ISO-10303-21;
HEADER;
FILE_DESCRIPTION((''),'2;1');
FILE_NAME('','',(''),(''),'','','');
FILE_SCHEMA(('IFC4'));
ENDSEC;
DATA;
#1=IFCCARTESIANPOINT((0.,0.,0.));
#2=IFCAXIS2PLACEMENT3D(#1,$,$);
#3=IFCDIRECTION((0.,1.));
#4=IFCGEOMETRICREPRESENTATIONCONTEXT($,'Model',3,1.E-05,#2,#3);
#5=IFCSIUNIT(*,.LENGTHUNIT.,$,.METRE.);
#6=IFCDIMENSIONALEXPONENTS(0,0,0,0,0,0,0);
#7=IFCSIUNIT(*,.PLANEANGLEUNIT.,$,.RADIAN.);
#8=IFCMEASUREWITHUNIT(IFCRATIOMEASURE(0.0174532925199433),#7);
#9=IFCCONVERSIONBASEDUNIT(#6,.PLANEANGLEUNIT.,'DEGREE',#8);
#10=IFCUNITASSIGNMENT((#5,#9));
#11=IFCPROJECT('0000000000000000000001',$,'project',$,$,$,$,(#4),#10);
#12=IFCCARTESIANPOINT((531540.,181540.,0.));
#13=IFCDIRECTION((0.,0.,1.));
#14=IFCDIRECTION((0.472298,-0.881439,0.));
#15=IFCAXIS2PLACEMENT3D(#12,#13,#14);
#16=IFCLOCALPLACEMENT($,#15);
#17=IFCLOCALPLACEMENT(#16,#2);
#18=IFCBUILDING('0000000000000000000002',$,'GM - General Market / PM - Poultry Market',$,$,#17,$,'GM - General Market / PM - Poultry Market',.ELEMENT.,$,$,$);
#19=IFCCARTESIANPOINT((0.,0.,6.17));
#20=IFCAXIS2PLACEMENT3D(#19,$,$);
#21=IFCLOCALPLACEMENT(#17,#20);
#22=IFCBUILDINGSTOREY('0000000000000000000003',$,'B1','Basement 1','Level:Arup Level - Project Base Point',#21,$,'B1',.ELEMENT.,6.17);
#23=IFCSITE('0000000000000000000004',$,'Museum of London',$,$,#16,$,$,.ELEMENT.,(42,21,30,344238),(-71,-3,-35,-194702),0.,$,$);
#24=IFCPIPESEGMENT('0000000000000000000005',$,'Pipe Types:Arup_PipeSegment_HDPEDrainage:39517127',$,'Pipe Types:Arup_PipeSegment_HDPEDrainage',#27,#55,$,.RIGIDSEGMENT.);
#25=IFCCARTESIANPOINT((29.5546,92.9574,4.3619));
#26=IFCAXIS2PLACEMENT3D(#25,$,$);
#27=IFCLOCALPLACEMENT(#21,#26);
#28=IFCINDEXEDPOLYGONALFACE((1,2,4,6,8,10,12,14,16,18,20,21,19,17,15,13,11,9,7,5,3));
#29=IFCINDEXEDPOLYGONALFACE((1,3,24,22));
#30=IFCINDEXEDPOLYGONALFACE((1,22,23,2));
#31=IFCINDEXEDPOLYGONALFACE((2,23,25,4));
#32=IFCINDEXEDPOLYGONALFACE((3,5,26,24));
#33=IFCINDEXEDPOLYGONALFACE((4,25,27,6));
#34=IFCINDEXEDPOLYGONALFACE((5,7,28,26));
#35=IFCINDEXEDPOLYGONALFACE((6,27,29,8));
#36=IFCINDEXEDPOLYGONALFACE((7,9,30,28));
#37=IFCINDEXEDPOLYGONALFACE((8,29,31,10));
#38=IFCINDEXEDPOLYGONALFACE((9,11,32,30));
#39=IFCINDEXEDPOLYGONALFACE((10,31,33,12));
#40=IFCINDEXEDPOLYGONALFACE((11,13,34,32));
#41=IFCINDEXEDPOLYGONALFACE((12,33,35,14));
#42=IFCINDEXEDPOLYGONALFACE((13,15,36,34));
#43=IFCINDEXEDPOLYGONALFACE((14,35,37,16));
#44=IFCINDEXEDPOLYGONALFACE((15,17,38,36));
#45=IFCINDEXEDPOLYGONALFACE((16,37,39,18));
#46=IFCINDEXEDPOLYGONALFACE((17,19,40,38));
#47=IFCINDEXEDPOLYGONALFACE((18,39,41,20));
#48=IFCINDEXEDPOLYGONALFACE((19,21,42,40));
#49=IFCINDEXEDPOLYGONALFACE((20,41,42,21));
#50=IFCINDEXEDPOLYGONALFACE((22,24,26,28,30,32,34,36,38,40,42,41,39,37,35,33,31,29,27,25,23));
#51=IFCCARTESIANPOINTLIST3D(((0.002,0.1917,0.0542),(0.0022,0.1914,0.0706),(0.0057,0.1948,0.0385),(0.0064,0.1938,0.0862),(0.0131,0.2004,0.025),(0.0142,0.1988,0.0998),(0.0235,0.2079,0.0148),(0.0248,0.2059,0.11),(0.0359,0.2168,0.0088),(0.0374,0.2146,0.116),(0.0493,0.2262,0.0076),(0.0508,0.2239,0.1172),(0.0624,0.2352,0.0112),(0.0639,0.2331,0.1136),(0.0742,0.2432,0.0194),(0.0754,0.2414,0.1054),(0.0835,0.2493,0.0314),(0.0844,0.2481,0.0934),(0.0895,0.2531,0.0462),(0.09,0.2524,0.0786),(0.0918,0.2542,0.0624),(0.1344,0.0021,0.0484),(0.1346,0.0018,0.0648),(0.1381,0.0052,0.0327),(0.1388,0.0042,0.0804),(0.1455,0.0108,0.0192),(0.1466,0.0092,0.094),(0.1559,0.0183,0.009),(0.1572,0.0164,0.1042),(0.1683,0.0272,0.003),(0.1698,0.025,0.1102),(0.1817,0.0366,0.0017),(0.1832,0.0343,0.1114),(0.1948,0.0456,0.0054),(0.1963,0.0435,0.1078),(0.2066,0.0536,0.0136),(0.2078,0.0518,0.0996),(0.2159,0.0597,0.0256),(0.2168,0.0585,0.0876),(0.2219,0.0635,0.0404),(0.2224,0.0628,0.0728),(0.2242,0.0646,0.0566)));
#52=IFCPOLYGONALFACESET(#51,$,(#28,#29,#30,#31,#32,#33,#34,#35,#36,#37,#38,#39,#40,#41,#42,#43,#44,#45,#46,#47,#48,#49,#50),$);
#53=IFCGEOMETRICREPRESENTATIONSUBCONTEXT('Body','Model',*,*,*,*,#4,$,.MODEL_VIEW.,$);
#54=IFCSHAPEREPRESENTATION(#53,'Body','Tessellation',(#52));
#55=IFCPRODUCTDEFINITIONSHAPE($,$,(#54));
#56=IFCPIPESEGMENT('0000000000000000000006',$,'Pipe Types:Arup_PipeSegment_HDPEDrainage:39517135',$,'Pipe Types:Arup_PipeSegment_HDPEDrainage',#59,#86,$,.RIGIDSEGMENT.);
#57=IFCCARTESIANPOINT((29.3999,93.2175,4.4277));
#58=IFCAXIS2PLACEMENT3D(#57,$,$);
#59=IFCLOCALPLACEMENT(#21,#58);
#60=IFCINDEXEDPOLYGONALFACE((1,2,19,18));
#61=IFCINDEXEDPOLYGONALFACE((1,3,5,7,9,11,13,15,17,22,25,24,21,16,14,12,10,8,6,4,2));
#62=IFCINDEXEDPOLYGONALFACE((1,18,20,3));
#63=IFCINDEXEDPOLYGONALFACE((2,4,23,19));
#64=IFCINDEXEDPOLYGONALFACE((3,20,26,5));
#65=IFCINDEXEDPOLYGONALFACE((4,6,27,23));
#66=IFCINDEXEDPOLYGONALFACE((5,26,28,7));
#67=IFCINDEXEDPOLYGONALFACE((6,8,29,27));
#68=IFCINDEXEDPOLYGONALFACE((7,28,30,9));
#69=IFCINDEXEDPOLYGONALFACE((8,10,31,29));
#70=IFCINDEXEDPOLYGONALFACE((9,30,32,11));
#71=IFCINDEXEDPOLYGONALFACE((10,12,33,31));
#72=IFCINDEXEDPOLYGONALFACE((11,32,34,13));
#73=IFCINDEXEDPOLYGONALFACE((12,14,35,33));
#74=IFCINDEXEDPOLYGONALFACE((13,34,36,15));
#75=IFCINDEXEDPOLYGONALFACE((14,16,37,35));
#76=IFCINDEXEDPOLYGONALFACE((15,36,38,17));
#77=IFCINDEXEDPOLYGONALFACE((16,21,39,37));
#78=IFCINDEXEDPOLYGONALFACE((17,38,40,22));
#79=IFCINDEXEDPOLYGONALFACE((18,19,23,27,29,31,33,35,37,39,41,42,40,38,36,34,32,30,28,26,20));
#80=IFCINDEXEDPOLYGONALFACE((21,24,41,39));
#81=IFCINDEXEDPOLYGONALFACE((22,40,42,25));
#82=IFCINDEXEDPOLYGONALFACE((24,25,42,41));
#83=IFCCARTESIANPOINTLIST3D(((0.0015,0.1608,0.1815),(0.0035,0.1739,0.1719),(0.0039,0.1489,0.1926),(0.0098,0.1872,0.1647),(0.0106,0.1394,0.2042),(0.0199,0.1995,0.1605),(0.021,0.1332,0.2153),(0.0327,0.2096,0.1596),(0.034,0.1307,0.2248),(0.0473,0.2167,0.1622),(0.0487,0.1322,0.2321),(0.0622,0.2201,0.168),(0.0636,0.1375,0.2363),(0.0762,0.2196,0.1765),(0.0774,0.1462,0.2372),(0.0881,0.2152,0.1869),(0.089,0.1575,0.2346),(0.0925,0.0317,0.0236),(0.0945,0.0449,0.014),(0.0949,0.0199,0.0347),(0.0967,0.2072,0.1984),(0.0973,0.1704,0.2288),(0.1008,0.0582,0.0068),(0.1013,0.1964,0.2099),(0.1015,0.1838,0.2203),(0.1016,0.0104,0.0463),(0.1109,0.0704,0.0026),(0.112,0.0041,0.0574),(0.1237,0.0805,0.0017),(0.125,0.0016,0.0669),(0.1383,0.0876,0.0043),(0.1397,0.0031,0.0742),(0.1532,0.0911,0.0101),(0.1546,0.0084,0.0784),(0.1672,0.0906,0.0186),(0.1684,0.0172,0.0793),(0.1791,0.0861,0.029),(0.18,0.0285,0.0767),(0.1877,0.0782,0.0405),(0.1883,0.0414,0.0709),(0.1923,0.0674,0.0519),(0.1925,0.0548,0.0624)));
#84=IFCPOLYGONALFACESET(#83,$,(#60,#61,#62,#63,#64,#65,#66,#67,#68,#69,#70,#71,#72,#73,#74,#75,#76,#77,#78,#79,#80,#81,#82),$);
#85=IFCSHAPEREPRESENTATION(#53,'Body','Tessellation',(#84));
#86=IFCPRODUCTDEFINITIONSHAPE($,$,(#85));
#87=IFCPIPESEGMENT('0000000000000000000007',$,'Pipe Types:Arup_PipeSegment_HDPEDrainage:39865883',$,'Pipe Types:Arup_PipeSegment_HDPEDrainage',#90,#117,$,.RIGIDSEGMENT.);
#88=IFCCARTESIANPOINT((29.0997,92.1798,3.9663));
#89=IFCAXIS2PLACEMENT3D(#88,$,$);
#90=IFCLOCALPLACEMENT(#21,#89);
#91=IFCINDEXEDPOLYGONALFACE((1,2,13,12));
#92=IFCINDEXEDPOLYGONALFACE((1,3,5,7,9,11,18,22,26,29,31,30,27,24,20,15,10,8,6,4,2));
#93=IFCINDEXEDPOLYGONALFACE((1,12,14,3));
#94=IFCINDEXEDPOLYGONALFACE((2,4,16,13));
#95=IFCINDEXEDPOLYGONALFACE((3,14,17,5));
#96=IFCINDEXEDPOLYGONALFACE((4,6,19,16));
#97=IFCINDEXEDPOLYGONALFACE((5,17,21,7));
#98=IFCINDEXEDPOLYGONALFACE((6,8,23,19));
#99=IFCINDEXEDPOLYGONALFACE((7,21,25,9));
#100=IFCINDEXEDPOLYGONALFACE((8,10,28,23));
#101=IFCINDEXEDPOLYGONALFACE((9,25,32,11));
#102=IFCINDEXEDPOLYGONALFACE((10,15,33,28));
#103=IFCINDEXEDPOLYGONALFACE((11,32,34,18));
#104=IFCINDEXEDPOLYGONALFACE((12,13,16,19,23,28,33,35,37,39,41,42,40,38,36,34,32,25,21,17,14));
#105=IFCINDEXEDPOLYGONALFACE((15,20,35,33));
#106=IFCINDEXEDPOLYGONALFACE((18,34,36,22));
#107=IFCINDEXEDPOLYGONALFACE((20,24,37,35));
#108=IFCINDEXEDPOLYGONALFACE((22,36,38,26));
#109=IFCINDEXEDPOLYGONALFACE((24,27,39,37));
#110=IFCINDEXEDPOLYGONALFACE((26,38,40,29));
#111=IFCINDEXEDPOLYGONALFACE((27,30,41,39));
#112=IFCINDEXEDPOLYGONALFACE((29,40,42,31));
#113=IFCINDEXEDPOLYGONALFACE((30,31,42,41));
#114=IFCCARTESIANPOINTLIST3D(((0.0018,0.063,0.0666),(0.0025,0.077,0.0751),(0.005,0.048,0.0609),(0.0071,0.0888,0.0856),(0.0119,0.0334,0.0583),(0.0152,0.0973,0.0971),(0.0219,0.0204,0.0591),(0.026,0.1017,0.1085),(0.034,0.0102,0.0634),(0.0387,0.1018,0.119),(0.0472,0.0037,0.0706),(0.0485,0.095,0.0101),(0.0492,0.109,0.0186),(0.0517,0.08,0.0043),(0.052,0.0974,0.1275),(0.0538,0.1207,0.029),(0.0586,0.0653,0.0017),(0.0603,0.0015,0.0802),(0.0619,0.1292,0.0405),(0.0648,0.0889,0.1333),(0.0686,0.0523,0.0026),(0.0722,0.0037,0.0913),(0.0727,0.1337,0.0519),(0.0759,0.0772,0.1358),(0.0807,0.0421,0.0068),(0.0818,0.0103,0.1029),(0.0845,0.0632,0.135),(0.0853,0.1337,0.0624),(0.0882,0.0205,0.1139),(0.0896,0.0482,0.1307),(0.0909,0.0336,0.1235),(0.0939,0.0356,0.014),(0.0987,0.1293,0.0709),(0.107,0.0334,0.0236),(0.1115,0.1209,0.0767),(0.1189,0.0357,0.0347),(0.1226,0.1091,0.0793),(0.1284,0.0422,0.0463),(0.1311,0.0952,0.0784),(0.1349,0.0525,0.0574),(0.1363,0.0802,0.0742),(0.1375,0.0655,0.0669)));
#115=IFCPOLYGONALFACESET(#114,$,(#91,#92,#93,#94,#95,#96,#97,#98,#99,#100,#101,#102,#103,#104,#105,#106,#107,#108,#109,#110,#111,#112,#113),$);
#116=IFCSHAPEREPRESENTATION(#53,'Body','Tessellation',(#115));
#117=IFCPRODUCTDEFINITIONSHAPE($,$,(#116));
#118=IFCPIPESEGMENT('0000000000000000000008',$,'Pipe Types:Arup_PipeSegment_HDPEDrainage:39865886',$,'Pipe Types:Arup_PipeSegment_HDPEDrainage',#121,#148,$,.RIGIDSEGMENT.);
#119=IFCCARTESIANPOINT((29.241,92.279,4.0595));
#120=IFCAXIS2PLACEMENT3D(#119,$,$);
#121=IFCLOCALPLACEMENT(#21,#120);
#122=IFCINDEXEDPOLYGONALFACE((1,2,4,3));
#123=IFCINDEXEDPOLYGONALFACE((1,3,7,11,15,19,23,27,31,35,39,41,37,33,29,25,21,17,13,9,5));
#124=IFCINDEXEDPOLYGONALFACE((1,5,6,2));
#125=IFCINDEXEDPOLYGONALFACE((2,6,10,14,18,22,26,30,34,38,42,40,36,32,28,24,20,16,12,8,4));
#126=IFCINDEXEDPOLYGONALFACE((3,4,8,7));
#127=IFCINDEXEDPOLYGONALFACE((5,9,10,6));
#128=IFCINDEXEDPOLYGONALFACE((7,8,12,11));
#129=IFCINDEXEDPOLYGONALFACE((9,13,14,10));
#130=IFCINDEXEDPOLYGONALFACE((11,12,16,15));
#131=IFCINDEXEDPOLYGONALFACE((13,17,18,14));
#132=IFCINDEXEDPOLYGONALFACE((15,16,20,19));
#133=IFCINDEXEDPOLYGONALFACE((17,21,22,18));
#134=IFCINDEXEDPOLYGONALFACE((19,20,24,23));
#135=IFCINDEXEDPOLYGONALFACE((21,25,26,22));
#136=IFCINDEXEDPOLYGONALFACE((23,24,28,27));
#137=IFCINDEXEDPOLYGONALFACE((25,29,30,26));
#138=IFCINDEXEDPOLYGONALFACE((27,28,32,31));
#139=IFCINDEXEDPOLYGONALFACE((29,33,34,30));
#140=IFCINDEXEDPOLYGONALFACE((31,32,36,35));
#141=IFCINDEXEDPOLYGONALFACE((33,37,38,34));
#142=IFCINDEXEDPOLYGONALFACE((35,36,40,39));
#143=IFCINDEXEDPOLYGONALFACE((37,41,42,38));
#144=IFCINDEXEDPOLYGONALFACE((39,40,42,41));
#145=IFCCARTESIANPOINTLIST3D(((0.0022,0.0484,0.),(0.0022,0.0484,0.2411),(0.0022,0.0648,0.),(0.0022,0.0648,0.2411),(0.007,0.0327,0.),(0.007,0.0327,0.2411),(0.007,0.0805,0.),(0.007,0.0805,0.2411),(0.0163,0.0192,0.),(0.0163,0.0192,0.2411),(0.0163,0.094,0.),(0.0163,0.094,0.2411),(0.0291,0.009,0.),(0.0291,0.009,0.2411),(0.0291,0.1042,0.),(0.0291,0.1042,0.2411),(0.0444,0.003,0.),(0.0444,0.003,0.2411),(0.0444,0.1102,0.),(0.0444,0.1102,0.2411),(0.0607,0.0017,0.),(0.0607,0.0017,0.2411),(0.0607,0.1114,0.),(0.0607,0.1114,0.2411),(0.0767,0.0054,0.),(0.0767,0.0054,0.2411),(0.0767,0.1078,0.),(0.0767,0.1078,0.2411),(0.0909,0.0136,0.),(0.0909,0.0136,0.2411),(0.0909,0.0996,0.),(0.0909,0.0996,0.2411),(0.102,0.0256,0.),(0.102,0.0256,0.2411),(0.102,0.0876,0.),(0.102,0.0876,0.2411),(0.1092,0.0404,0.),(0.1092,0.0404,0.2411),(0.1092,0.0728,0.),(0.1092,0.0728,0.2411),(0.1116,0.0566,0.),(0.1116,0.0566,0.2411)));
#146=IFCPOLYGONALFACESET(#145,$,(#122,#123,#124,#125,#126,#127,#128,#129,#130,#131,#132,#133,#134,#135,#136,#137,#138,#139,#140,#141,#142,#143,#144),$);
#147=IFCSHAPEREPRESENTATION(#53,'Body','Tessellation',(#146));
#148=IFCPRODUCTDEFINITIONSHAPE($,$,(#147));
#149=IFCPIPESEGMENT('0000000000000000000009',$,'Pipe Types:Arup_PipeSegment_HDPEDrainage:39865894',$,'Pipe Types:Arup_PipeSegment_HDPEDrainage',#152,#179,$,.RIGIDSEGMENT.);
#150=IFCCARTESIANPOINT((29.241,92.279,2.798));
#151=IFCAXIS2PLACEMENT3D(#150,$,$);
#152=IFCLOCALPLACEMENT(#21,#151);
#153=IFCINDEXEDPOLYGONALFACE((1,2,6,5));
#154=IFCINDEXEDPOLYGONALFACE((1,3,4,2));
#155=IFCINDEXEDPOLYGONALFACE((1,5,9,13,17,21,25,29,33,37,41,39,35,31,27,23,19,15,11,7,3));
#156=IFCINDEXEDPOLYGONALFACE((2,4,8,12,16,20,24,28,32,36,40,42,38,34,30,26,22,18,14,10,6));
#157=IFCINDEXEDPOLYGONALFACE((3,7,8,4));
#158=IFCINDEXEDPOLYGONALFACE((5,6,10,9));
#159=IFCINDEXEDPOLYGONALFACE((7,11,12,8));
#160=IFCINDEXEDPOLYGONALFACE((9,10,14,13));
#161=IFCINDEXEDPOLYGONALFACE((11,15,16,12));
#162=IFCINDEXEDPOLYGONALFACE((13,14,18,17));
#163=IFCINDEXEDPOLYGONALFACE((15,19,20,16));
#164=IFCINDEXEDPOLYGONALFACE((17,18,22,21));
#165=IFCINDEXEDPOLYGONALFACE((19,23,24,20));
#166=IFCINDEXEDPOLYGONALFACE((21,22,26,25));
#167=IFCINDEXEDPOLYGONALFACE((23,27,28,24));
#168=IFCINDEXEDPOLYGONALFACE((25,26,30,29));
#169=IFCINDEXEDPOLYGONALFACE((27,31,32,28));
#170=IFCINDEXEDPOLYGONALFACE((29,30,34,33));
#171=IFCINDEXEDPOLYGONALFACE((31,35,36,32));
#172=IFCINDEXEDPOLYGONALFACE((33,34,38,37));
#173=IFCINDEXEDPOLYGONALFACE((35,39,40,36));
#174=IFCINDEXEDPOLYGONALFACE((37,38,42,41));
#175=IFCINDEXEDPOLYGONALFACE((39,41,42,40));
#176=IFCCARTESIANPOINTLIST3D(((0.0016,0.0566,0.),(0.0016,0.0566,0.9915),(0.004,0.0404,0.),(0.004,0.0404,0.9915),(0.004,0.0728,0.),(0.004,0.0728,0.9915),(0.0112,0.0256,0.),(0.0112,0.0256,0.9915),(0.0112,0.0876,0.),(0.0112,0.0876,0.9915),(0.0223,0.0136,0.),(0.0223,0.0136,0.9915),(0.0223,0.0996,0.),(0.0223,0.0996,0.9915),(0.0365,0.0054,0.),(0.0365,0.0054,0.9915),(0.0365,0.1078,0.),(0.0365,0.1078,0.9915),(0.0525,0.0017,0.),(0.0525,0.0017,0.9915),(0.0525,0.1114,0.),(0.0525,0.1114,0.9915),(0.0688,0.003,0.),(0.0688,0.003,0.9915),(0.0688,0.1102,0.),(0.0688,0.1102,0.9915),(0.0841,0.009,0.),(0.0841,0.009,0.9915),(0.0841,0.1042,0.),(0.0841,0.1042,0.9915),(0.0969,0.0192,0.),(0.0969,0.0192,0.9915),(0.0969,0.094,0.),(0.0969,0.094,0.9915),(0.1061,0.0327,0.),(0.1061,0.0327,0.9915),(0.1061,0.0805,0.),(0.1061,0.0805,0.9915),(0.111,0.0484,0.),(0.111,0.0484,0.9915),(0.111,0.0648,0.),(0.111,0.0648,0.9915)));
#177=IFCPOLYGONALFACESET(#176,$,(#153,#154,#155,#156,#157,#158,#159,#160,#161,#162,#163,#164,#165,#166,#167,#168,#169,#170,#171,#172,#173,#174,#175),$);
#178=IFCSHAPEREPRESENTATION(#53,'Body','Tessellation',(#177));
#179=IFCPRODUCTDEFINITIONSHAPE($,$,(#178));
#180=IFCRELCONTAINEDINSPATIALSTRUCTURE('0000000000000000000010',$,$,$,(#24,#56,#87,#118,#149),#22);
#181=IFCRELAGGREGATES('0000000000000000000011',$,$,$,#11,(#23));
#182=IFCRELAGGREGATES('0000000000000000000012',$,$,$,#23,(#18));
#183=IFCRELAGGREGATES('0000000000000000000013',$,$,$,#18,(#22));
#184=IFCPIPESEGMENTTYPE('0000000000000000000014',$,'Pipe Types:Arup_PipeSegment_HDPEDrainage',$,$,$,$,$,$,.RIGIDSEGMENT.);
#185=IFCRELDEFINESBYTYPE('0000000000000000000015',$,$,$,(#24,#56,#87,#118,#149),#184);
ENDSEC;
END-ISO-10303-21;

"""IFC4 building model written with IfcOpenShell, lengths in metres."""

from ifc_helpers import new_model, entity, si_unit, converted_unit, direction, frame, frame_2d, origin, origin_2d_with_axis, place, context, subcontext, project, spatial, circle, extrude, type_object, element, save


model = new_model("IFC4")

# Units and contexts
model_context = context("Model", 3, precision=1e-05, world=origin(), true_north=direction((0.0, 1.0)))
body_context = subcontext(model_context, "Body", "Model", "MODEL_VIEW")
ifc_project = project(units=[si_unit("LENGTHUNIT", "METRE"), converted_unit("PLANEANGLEUNIT", "DEGREE", entity("IfcRatioMeasure", 0.0174532925199433), si_unit("PLANEANGLEUNIT", "RADIAN"), dimensions=[0, 0, 0, 0, 0, 0, 0])], contexts=[model_context])

# Site, building, storey
site_placement = place(None, frame((531540.0, 181540.0, 0.0), z_axis=(0.0, 0.0, 1.0), x_axis=(0.472298, -0.881439, 0.0)))
site = spatial("IfcSite", under=ifc_project, at=site_placement, Name="Museum of London", CompositionType="ELEMENT", RefLatitude=(42, 21, 30, 344238), RefLongitude=(-71, -3, -35, -194702), RefElevation=0.0)
building_placement = place(site_placement, origin())
building = spatial("IfcBuilding", under=site, at=building_placement, Name="GM - General Market / PM - Poultry Market", LongName="GM - General Market / PM - Poultry Market", CompositionType="ELEMENT")
storey_placement = place(building_placement, frame((0.0, 0.0, 6.17)))
storey = spatial("IfcBuildingStorey", under=building, at=storey_placement, Name="B1", Description="Basement 1", ObjectType="Level:Arup Level - Project Base Point", LongName="B1", CompositionType="ELEMENT", Elevation=6.17)

# Pipe segments
pipe_segment_type_1 = type_object("IfcPipeSegmentType", Name="Pipe Types:Arup_PipeSegment_HDPEDrainage", PredefinedType="RIGIDSEGMENT")
pipe_segment_1_placement = place(storey_placement, frame((29.5546, 92.9574, 4.3619)))
element("IfcPipeSegment", 1, at=pipe_segment_1_placement, inside=storey, type_object=pipe_segment_type_1, Name="Pipe Types:Arup_PipeSegment_HDPEDrainage:39517127", ObjectType="Pipe Types:Arup_PipeSegment_HDPEDrainage", PredefinedType="RIGIDSEGMENT", context=body_context, shape_type="SweptSolid", body=[
    extrude(circle(Radius=0.055, at=frame_2d((0.0, 0.0), x_axis=(1.0, 0.0))), frame((0.1791, 0.0331, 0.0566), z_axis=(-0.572376, 0.819607, 0.025109), x_axis=(0.819866, 0.572556, 0.0)), (0.0, 0.0, 1.0), 0.2313),
])
pipe_segment_2_placement = place(storey_placement, frame((29.3999, 93.2175, 4.4277)))
element("IfcPipeSegment", 2, at=pipe_segment_2_placement, inside=storey, type_object=pipe_segment_type_1, Name="Pipe Types:Arup_PipeSegment_HDPEDrainage:39517135", ObjectType="Pipe Types:Arup_PipeSegment_HDPEDrainage", PredefinedType="RIGIDSEGMENT", context=body_context, shape_type="SweptSolid", body=[
    extrude(circle(Radius=0.055, at=origin_2d_with_axis()), frame((0.1427, 0.0465, 0.0405), z_axis=(-0.407514, 0.577871, 0.707105), x_axis=(0.817231, 0.576311, 0.0)), (0.0, 0.0, 1.0), 0.2233),
])
pipe_segment_3_placement = place(storey_placement, frame((29.0997, 92.1798, 3.9663)))
element("IfcPipeSegment", 3, at=pipe_segment_3_placement, inside=storey, type_object=pipe_segment_type_1, Name="Pipe Types:Arup_PipeSegment_HDPEDrainage:39865883", ObjectType="Pipe Types:Arup_PipeSegment_HDPEDrainage", PredefinedType="RIGIDSEGMENT", context=body_context, shape_type="SweptSolid", body=[
    extrude(circle(Radius=0.055, at=origin_2d_with_axis()), frame((0.0463, 0.0519, 0.0971), z_axis=(0.583479, 0.39944, -0.707107), x_axis=(-0.564893, 0.825164, 0.0)), (0.0, 0.0, 1.0), 0.08),
])
pipe_segment_4_placement = place(storey_placement, frame((29.241, 92.279, 4.0595)))
element("IfcPipeSegment", 4, at=pipe_segment_4_placement, inside=storey, type_object=pipe_segment_type_1, Name="Pipe Types:Arup_PipeSegment_HDPEDrainage:39865886", ObjectType="Pipe Types:Arup_PipeSegment_HDPEDrainage", PredefinedType="RIGIDSEGMENT", context=body_context, shape_type="SweptSolid", body=[
    extrude(circle(Radius=0.055, at=origin_2d_with_axis()), frame((0.0566, 0.0566, 0.0)), (0.0, 0.0, 1.0), 0.2411),
])
pipe_segment_5_placement = place(storey_placement, frame((29.241, 92.279, 2.798)))
element("IfcPipeSegment", 5, at=pipe_segment_5_placement, inside=storey, type_object=pipe_segment_type_1, Name="Pipe Types:Arup_PipeSegment_HDPEDrainage:39865894", ObjectType="Pipe Types:Arup_PipeSegment_HDPEDrainage", PredefinedType="RIGIDSEGMENT", context=body_context, shape_type="SweptSolid", body=[
    extrude(circle(Radius=0.055, at=origin_2d_with_axis()), frame((0.0566, 0.0566, 0.0), z_axis=(0.0, 0.0, 1.0), x_axis=(-1.0, 0.0, 0.0)), (0.0, 0.0, 1.0), 0.9915),
])

save(model, "model.ifc")
